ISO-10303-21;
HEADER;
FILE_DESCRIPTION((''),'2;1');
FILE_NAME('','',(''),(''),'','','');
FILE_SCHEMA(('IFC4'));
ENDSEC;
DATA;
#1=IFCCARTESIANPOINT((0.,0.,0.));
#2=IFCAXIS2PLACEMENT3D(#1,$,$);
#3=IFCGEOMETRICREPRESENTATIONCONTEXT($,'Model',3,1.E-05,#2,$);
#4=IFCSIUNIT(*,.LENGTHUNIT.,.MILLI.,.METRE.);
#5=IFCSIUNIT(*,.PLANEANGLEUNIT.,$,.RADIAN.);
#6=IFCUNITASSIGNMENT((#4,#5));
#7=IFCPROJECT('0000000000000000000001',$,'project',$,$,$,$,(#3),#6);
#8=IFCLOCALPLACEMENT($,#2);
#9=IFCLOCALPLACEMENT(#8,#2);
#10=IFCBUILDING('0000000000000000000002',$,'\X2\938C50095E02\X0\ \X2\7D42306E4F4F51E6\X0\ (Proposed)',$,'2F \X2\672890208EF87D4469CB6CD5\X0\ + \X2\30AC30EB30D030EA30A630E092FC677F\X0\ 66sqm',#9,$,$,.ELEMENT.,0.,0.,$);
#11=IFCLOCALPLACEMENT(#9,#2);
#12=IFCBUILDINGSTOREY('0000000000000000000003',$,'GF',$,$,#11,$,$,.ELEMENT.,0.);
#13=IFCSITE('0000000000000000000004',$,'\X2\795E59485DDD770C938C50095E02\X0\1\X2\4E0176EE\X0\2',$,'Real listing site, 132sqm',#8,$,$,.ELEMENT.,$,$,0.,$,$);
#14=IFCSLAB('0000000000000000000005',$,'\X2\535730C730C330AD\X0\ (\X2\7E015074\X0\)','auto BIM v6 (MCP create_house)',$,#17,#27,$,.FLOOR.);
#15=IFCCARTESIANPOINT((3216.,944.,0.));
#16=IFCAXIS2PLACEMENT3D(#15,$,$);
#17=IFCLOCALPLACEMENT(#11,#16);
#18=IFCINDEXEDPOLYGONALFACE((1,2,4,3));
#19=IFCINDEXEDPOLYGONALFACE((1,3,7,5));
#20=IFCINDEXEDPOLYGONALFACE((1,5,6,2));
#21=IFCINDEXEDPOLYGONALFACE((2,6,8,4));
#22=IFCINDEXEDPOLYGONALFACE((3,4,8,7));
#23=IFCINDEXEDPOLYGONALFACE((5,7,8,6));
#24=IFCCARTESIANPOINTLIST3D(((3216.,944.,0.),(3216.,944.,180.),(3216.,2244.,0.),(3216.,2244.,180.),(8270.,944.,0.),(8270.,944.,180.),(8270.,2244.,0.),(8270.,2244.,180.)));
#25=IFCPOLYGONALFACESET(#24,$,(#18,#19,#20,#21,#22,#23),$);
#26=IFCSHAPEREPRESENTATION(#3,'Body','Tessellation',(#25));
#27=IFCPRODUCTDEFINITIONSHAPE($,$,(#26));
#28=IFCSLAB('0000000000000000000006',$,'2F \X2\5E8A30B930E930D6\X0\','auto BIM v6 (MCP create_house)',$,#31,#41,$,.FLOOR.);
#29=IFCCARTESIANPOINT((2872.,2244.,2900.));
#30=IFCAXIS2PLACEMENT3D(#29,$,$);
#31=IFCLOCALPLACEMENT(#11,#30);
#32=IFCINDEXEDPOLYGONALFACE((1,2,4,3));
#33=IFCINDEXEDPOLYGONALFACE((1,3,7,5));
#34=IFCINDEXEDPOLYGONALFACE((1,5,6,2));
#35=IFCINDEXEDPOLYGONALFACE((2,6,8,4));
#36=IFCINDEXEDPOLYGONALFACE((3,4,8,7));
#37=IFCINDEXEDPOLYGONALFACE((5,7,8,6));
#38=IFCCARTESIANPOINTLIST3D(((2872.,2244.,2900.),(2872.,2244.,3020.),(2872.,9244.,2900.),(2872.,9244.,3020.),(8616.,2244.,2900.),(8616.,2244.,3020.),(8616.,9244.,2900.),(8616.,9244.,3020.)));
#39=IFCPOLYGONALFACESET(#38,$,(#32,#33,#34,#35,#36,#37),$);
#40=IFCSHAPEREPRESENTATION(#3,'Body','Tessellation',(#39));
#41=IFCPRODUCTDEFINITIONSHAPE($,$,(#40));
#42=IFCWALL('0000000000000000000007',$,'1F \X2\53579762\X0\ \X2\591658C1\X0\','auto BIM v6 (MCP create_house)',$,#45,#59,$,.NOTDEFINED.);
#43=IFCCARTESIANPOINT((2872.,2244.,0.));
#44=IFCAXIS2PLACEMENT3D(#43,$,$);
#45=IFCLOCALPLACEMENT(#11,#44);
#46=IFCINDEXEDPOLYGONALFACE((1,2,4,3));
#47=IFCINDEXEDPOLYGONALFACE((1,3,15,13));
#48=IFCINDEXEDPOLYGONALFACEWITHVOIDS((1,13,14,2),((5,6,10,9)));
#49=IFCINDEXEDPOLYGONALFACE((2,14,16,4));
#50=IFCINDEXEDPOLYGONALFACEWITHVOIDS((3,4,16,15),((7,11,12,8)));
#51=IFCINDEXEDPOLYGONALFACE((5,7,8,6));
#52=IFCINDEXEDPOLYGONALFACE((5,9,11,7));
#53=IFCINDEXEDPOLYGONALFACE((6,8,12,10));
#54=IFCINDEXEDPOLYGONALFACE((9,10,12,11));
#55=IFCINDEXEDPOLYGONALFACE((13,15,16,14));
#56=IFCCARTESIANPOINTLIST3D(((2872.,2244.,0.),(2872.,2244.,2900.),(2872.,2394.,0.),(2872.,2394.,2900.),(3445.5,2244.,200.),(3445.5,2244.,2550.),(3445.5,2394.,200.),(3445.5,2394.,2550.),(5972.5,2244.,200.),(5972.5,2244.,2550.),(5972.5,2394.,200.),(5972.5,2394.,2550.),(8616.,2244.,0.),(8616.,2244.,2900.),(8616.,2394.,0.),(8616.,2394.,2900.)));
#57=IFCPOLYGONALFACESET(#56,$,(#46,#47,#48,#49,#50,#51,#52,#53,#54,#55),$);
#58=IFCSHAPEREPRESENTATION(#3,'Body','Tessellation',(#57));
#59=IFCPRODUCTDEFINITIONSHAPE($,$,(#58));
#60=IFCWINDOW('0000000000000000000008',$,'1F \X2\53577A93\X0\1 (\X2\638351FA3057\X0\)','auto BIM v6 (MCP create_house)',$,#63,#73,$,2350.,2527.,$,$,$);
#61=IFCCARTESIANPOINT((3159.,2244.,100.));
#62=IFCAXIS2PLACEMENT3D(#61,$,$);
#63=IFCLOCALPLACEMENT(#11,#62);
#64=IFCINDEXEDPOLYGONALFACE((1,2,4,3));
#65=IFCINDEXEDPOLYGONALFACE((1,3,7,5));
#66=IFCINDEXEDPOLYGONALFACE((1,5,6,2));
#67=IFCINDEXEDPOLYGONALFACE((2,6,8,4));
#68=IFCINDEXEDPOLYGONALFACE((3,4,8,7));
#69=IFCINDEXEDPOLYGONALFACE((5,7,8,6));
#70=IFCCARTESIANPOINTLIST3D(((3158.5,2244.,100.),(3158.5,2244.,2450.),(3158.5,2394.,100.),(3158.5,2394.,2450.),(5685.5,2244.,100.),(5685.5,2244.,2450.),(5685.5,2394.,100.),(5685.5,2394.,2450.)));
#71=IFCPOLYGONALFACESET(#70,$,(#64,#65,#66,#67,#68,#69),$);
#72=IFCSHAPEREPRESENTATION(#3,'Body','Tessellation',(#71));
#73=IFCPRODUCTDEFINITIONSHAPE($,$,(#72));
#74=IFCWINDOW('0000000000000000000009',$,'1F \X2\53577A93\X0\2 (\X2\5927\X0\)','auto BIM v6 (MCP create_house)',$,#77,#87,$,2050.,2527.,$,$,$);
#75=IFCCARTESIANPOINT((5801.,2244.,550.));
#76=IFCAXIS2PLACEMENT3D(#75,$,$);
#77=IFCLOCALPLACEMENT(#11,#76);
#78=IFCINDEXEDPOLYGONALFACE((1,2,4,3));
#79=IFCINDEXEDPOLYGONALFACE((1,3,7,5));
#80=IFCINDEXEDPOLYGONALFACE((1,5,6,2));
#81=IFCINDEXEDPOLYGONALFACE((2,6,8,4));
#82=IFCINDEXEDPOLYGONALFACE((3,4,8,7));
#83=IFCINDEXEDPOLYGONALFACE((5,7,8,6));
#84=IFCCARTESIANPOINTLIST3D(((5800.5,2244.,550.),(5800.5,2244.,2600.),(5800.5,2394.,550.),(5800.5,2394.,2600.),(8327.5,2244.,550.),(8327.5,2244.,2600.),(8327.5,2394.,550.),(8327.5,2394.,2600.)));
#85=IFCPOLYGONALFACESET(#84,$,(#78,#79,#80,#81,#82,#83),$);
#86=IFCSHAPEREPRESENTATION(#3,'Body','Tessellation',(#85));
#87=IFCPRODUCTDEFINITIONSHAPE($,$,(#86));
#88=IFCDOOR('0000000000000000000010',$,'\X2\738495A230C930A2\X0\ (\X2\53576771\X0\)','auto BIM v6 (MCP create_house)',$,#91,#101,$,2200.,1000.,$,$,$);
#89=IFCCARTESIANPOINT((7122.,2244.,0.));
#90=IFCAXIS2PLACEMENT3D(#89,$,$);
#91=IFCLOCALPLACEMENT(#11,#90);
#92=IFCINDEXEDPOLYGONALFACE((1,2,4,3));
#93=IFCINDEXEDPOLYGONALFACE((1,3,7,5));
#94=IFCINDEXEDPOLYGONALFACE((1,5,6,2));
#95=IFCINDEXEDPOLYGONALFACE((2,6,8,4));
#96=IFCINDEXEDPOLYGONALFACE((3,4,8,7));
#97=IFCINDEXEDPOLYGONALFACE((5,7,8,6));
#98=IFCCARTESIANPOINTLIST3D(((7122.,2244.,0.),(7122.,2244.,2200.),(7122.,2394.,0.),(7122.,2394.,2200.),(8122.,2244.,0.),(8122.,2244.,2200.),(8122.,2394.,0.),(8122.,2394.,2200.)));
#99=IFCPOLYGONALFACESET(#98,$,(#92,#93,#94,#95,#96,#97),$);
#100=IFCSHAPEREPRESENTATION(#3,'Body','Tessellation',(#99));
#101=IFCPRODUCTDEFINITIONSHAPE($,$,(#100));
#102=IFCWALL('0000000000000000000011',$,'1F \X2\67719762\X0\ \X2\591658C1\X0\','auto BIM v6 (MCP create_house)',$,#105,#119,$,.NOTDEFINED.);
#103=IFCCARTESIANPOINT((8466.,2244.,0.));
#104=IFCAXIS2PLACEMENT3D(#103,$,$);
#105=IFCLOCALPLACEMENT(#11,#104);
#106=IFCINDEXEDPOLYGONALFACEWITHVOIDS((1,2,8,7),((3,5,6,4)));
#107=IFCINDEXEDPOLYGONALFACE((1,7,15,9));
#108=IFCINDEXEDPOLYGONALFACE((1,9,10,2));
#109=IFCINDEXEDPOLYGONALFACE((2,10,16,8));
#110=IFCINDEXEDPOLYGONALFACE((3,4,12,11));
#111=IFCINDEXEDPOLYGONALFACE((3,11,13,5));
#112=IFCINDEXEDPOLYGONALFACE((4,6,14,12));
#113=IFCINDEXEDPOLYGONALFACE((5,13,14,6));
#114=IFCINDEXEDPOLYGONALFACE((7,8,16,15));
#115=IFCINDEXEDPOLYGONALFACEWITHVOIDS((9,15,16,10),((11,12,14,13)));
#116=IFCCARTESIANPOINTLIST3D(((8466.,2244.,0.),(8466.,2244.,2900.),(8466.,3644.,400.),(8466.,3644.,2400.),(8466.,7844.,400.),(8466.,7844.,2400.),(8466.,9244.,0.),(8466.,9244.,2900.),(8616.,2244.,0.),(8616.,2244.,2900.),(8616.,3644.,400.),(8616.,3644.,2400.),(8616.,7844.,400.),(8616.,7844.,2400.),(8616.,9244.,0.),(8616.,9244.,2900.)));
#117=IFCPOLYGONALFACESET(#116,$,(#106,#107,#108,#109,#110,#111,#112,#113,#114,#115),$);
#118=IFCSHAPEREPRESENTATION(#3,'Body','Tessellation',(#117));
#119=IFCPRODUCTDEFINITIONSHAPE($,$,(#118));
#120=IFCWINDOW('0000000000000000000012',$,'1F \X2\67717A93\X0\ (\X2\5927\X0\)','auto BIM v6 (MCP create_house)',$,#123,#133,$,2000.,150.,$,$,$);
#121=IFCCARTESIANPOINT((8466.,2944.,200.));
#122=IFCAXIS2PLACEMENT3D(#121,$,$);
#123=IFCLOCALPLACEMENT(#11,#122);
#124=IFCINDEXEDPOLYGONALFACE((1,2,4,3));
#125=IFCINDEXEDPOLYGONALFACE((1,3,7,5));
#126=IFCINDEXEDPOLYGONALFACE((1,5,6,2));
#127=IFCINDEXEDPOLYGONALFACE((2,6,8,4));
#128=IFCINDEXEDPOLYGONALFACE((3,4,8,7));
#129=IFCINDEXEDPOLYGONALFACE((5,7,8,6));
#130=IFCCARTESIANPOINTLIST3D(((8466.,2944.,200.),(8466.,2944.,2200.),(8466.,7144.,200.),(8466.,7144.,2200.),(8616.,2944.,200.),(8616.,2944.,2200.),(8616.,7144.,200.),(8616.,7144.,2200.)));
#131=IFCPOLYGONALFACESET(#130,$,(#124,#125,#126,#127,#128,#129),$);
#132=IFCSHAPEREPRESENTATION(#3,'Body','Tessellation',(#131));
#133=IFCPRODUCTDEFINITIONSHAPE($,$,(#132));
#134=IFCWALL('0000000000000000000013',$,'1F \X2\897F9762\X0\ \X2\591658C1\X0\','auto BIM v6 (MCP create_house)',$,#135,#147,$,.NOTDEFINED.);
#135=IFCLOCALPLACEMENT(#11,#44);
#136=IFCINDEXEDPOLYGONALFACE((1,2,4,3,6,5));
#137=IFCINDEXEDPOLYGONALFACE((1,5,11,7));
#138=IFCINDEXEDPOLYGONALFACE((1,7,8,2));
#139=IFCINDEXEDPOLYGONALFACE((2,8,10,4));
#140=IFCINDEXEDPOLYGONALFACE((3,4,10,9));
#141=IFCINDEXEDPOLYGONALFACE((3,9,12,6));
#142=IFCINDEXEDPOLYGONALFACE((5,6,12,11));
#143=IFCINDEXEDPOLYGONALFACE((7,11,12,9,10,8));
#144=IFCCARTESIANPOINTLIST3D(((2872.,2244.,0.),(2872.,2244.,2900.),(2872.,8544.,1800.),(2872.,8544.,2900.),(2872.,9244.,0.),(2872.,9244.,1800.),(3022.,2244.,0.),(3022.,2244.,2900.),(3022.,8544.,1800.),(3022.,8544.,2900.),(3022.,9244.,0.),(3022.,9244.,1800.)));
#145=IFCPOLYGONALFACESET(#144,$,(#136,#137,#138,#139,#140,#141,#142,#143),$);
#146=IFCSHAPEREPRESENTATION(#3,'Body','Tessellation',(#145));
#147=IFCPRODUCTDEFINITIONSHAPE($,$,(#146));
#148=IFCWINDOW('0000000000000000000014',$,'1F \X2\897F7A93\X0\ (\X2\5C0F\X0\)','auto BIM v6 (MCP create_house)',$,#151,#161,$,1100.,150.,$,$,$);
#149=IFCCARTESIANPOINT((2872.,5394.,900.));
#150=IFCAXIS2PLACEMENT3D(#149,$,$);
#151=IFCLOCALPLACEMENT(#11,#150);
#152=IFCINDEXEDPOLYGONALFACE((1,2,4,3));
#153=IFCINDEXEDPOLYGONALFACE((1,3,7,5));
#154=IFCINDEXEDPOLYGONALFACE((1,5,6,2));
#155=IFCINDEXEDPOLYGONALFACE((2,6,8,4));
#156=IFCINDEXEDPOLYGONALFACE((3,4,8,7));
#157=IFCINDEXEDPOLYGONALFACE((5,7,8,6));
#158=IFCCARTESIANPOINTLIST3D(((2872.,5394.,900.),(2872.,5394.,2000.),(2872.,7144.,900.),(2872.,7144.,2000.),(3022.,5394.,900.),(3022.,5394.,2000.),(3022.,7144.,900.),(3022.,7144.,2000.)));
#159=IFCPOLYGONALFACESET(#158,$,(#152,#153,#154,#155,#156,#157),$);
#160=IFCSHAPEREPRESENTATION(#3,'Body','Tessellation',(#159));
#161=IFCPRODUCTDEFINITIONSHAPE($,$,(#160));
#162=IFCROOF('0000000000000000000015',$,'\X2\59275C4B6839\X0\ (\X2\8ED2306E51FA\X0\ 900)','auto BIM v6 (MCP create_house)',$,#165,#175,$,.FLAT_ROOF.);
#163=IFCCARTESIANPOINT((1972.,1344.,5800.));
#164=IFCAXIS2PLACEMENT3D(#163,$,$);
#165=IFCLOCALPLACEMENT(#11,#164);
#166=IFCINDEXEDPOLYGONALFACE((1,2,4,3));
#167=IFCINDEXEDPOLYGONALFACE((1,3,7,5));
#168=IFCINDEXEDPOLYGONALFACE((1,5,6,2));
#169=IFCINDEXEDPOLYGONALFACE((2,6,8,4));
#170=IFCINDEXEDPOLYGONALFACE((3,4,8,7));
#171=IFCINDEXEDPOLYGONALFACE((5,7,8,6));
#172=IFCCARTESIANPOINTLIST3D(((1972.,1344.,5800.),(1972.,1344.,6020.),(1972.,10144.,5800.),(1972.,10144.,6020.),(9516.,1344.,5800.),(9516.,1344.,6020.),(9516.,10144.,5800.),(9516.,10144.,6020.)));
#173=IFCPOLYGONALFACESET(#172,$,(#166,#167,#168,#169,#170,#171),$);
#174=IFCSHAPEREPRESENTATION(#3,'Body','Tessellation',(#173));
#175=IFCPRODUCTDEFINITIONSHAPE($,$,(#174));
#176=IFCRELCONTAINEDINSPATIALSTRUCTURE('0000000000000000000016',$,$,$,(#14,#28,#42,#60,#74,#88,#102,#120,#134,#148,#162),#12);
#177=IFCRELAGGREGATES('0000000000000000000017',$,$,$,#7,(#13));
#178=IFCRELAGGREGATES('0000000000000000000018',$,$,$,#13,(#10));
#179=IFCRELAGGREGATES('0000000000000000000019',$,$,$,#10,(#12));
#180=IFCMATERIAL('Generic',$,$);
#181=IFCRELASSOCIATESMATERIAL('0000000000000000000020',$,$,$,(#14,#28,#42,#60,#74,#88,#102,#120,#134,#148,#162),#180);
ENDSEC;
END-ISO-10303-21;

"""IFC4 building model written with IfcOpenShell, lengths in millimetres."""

from ifc_helpers import new_model, si_unit, frame, frame_2d, origin, place, context, project, spatial, rectangle, extrude, material, element, fill, save


model = new_model("IFC4")

# Units and contexts
model_context = context("Model", 3, precision=1e-05, world=origin())
ifc_project = project(units=[si_unit("LENGTHUNIT", "METRE", prefix="MILLI"), si_unit("PLANEANGLEUNIT", "RADIAN")], contexts=[model_context])

# Site, building, storey
site_placement = place(None, origin())
site = spatial("IfcSite", under=ifc_project, at=site_placement, Name="神奈川県鎌倉市1丁目2", ObjectType="Real listing site, 132sqm", CompositionType="ELEMENT", RefElevation=0.0)
building_placement = place(site_placement, origin())
building = spatial("IfcBuilding", under=site, at=building_placement, Name="鎌倉市 終の住処 (Proposed)", ObjectType="2F 木造軸組構法 + ガルバリウム鋼板 66sqm", CompositionType="ELEMENT", ElevationOfRefHeight=0.0, ElevationOfTerrain=0.0)
storey_placement = place(building_placement, origin())
storey = spatial("IfcBuildingStorey", under=building, at=storey_placement, Name="GF", CompositionType="ELEMENT", Elevation=0.0)

# Slabs
ifc_material = material(Name="Generic")
slab_1_placement = place(storey_placement, frame((3216.0, 944.0, 0.0)))
element("IfcSlab", 1, at=slab_1_placement, inside=storey, material=ifc_material, Name="南デッキ (縁側)", Description="auto BIM v6 (MCP create_house)", PredefinedType="FLOOR", context=model_context, shape_type="SweptSolid", body=[
    extrude(rectangle(XDim=5054.0, YDim=1300.0, at=frame_2d((2527.0, 650.0))), frame((3216.0, 944.0, 0.0)), (0.0, 0.0, 1.0), 180.0),
])
slab_2_placement = place(storey_placement, frame((2872.0, 2244.0, 2900.0)))
element("IfcSlab", 2, at=slab_2_placement, inside=storey, material=ifc_material, Name="2F 床スラブ", Description="auto BIM v6 (MCP create_house)", PredefinedType="FLOOR", context=model_context, shape_type="SweptSolid", body=[
    extrude(rectangle(XDim=5744.0, YDim=7000.0, at=frame_2d((2872.0, 3500.0))), frame((2872.0, 2244.0, 2900.0)), (0.0, 0.0, 1.0), 120.0),
])

# Wall, openings, windows, door
wall_1_placement = place(storey_placement, frame((2872.0, 2244.0, 0.0)))
wall_1 = element("IfcWall", 3, at=wall_1_placement, inside=storey, material=ifc_material, Name="1F 南面 外壁", Description="auto BIM v6 (MCP create_house)", PredefinedType="NOTDEFINED", context=model_context, shape_type="SweptSolid", body=[
    extrude(rectangle(XDim=5744.0, YDim=150.0, at=frame_2d((2872.0, 75.0))), frame((2872.0, 2244.0, 0.0)), (0.0, 0.0, 1.0), 2900.0),
])
opening_1_placement = place(storey_placement, frame((3159.0, 2244.0, 100.0)))
opening_1 = element("IfcOpeningElement", 4, at=opening_1_placement, cuts=wall_1, PredefinedType="NOTDEFINED", context=model_context, shape_type="SweptSolid", body=[
    extrude(rectangle(XDim=2527.0, YDim=150.0, at=frame_2d((1263.0, 75.0))), frame((3159.0, 2244.0, 100.0)), (0.0, 0.0, 1.0), 2350.0),
])
opening_2_placement = place(storey_placement, frame((5801.0, 2244.0, 550.0)))
opening_2 = element("IfcOpeningElement", 5, at=opening_2_placement, cuts=wall_1, PredefinedType="NOTDEFINED", context=model_context, shape_type="SweptSolid", body=[
    extrude(rectangle(XDim=2527.0, YDim=150.0, at=frame_2d((1263.0, 75.0))), frame((5801.0, 2244.0, 550.0)), (0.0, 0.0, 1.0), 2050.0),
])
opening_3_placement = place(storey_placement, frame((7122.0, 2244.0, 0.0)))
opening_3 = element("IfcOpeningElement", 6, at=opening_3_placement, cuts=wall_1, PredefinedType="NOTDEFINED", context=model_context, shape_type="SweptSolid", body=[
    extrude(rectangle(XDim=1000.0, YDim=150.0, at=frame_2d((500.0, 75.0))), frame((7122.0, 2244.0, 0.0)), (0.0, 0.0, 1.0), 2200.0),
])
window_1_placement = place(storey_placement, frame((3159.0, 2244.0, 100.0)))
window_1 = element("IfcWindow", 7, at=window_1_placement, inside=storey, material=ifc_material, Name="1F 南窓1 (掃出し)", Description="auto BIM v6 (MCP create_house)", OverallHeight=2350.0, OverallWidth=2527.0, context=model_context, shape_type="SweptSolid", body=[
    extrude(rectangle(XDim=2527.0, YDim=150.0, at=frame_2d((1263.0, 75.0))), frame((3159.0, 2244.0, 100.0)), (0.0, 0.0, 1.0), 2350.0),
])
fill(opening_1, window_1)
window_2_placement = place(storey_placement, frame((5801.0, 2244.0, 550.0)))
window_2 = element("IfcWindow", 8, at=window_2_placement, inside=storey, material=ifc_material, Name="1F 南窓2 (大)", Description="auto BIM v6 (MCP create_house)", OverallHeight=2050.0, OverallWidth=2527.0, context=model_context, shape_type="SweptSolid", body=[
    extrude(rectangle(XDim=2527.0, YDim=150.0, at=frame_2d((1263.0, 75.0))), frame((5801.0, 2244.0, 550.0)), (0.0, 0.0, 1.0), 2050.0),
])
fill(opening_2, window_2)
door_placement = place(storey_placement, frame((7122.0, 2244.0, 0.0)))
door = element("IfcDoor", 9, at=door_placement, inside=storey, material=ifc_material, Name="玄関ドア (南東)", Description="auto BIM v6 (MCP create_house)", OverallHeight=2200.0, OverallWidth=1000.0, context=model_context, shape_type="SweptSolid", body=[
    extrude(rectangle(XDim=1000.0, YDim=150.0, at=frame_2d((500.0, 75.0))), frame((7122.0, 2244.0, 0.0)), (0.0, 0.0, 1.0), 2200.0),
])
fill(opening_3, door)

# Walls, openings, windows
wall_2_placement = place(storey_placement, frame((8466.0, 2244.0, 0.0)))
wall_2 = element("IfcWall", 10, at=wall_2_placement, inside=storey, material=ifc_material, Name="1F 東面 外壁", Description="auto BIM v6 (MCP create_house)", PredefinedType="NOTDEFINED", context=model_context, shape_type="SweptSolid", body=[
    extrude(rectangle(XDim=150.0, YDim=7000.0, at=frame_2d((75.0, 3500.0))), frame((8466.0, 2244.0, 0.0)), (0.0, 0.0, 1.0), 2900.0),
])
opening_4_placement = place(storey_placement, frame((8466.0, 2944.0, 200.0)))
opening_4 = element("IfcOpeningElement", 11, at=opening_4_placement, cuts=wall_2, PredefinedType="NOTDEFINED", context=model_context, shape_type="SweptSolid", body=[
    extrude(rectangle(XDim=150.0, YDim=4200.0, at=frame_2d((75.0, 2100.0))), frame((8466.0, 2944.0, 200.0)), (0.0, 0.0, 1.0), 2000.0),
])
window_3_placement = place(storey_placement, frame((8466.0, 2944.0, 200.0)))
window_3 = element("IfcWindow", 12, at=window_3_placement, inside=storey, material=ifc_material, Name="1F 東窓 (大)", Description="auto BIM v6 (MCP create_house)", OverallHeight=2000.0, OverallWidth=150.0, context=model_context, shape_type="SweptSolid", body=[
    extrude(rectangle(XDim=150.0, YDim=4200.0, at=frame_2d((75.0, 2100.0))), frame((8466.0, 2944.0, 200.0)), (0.0, 0.0, 1.0), 2000.0),
])
fill(opening_4, window_3)
wall_3_placement = place(storey_placement, frame((2872.0, 2244.0, 0.0)))
wall_3 = element("IfcWall", 13, at=wall_3_placement, inside=storey, material=ifc_material, Name="1F 西面 外壁", Description="auto BIM v6 (MCP create_house)", PredefinedType="NOTDEFINED", context=model_context, shape_type="SweptSolid", body=[
    extrude(rectangle(XDim=150.0, YDim=7000.0, at=frame_2d((75.0, 3500.0))), frame((2872.0, 2244.0, 0.0)), (0.0, 0.0, 1.0), 2900.0),
])
opening_5_placement = place(storey_placement, frame((2872.0, 5394.0, 900.0)))
opening_5 = element("IfcOpeningElement", 14, at=opening_5_placement, cuts=wall_3, PredefinedType="NOTDEFINED", context=model_context, shape_type="SweptSolid", body=[
    extrude(rectangle(XDim=150.0, YDim=1750.0, at=frame_2d((75.0, 875.0))), frame((2872.0, 5394.0, 900.0)), (0.0, 0.0, 1.0), 1100.0),
])
window_4_placement = place(storey_placement, frame((2872.0, 5394.0, 900.0)))
window_4 = element("IfcWindow", 15, at=window_4_placement, inside=storey, material=ifc_material, Name="1F 西窓 (小)", Description="auto BIM v6 (MCP create_house)", OverallHeight=1100.0, OverallWidth=150.0, context=model_context, shape_type="SweptSolid", body=[
    extrude(rectangle(XDim=150.0, YDim=1750.0, at=frame_2d((75.0, 875.0))), frame((2872.0, 5394.0, 900.0)), (0.0, 0.0, 1.0), 1100.0),
])
fill(opening_5, window_4)

# Roof
roof_placement = place(storey_placement, frame((1972.0, 1344.0, 5800.0)))
element("IfcRoof", 16, at=roof_placement, inside=storey, material=ifc_material, Name="大屋根 (軒の出 900)", Description="auto BIM v6 (MCP create_house)", PredefinedType="FLAT_ROOF", context=model_context, shape_type="SweptSolid", body=[
    extrude(rectangle(XDim=7544.0, YDim=8800.0, at=frame_2d((3772.0, 4400.0))), frame((1972.0, 1344.0, 5800.0)), (0.0, 0.0, 1.0), 220.0),
])

save(model, "model.ifc")
